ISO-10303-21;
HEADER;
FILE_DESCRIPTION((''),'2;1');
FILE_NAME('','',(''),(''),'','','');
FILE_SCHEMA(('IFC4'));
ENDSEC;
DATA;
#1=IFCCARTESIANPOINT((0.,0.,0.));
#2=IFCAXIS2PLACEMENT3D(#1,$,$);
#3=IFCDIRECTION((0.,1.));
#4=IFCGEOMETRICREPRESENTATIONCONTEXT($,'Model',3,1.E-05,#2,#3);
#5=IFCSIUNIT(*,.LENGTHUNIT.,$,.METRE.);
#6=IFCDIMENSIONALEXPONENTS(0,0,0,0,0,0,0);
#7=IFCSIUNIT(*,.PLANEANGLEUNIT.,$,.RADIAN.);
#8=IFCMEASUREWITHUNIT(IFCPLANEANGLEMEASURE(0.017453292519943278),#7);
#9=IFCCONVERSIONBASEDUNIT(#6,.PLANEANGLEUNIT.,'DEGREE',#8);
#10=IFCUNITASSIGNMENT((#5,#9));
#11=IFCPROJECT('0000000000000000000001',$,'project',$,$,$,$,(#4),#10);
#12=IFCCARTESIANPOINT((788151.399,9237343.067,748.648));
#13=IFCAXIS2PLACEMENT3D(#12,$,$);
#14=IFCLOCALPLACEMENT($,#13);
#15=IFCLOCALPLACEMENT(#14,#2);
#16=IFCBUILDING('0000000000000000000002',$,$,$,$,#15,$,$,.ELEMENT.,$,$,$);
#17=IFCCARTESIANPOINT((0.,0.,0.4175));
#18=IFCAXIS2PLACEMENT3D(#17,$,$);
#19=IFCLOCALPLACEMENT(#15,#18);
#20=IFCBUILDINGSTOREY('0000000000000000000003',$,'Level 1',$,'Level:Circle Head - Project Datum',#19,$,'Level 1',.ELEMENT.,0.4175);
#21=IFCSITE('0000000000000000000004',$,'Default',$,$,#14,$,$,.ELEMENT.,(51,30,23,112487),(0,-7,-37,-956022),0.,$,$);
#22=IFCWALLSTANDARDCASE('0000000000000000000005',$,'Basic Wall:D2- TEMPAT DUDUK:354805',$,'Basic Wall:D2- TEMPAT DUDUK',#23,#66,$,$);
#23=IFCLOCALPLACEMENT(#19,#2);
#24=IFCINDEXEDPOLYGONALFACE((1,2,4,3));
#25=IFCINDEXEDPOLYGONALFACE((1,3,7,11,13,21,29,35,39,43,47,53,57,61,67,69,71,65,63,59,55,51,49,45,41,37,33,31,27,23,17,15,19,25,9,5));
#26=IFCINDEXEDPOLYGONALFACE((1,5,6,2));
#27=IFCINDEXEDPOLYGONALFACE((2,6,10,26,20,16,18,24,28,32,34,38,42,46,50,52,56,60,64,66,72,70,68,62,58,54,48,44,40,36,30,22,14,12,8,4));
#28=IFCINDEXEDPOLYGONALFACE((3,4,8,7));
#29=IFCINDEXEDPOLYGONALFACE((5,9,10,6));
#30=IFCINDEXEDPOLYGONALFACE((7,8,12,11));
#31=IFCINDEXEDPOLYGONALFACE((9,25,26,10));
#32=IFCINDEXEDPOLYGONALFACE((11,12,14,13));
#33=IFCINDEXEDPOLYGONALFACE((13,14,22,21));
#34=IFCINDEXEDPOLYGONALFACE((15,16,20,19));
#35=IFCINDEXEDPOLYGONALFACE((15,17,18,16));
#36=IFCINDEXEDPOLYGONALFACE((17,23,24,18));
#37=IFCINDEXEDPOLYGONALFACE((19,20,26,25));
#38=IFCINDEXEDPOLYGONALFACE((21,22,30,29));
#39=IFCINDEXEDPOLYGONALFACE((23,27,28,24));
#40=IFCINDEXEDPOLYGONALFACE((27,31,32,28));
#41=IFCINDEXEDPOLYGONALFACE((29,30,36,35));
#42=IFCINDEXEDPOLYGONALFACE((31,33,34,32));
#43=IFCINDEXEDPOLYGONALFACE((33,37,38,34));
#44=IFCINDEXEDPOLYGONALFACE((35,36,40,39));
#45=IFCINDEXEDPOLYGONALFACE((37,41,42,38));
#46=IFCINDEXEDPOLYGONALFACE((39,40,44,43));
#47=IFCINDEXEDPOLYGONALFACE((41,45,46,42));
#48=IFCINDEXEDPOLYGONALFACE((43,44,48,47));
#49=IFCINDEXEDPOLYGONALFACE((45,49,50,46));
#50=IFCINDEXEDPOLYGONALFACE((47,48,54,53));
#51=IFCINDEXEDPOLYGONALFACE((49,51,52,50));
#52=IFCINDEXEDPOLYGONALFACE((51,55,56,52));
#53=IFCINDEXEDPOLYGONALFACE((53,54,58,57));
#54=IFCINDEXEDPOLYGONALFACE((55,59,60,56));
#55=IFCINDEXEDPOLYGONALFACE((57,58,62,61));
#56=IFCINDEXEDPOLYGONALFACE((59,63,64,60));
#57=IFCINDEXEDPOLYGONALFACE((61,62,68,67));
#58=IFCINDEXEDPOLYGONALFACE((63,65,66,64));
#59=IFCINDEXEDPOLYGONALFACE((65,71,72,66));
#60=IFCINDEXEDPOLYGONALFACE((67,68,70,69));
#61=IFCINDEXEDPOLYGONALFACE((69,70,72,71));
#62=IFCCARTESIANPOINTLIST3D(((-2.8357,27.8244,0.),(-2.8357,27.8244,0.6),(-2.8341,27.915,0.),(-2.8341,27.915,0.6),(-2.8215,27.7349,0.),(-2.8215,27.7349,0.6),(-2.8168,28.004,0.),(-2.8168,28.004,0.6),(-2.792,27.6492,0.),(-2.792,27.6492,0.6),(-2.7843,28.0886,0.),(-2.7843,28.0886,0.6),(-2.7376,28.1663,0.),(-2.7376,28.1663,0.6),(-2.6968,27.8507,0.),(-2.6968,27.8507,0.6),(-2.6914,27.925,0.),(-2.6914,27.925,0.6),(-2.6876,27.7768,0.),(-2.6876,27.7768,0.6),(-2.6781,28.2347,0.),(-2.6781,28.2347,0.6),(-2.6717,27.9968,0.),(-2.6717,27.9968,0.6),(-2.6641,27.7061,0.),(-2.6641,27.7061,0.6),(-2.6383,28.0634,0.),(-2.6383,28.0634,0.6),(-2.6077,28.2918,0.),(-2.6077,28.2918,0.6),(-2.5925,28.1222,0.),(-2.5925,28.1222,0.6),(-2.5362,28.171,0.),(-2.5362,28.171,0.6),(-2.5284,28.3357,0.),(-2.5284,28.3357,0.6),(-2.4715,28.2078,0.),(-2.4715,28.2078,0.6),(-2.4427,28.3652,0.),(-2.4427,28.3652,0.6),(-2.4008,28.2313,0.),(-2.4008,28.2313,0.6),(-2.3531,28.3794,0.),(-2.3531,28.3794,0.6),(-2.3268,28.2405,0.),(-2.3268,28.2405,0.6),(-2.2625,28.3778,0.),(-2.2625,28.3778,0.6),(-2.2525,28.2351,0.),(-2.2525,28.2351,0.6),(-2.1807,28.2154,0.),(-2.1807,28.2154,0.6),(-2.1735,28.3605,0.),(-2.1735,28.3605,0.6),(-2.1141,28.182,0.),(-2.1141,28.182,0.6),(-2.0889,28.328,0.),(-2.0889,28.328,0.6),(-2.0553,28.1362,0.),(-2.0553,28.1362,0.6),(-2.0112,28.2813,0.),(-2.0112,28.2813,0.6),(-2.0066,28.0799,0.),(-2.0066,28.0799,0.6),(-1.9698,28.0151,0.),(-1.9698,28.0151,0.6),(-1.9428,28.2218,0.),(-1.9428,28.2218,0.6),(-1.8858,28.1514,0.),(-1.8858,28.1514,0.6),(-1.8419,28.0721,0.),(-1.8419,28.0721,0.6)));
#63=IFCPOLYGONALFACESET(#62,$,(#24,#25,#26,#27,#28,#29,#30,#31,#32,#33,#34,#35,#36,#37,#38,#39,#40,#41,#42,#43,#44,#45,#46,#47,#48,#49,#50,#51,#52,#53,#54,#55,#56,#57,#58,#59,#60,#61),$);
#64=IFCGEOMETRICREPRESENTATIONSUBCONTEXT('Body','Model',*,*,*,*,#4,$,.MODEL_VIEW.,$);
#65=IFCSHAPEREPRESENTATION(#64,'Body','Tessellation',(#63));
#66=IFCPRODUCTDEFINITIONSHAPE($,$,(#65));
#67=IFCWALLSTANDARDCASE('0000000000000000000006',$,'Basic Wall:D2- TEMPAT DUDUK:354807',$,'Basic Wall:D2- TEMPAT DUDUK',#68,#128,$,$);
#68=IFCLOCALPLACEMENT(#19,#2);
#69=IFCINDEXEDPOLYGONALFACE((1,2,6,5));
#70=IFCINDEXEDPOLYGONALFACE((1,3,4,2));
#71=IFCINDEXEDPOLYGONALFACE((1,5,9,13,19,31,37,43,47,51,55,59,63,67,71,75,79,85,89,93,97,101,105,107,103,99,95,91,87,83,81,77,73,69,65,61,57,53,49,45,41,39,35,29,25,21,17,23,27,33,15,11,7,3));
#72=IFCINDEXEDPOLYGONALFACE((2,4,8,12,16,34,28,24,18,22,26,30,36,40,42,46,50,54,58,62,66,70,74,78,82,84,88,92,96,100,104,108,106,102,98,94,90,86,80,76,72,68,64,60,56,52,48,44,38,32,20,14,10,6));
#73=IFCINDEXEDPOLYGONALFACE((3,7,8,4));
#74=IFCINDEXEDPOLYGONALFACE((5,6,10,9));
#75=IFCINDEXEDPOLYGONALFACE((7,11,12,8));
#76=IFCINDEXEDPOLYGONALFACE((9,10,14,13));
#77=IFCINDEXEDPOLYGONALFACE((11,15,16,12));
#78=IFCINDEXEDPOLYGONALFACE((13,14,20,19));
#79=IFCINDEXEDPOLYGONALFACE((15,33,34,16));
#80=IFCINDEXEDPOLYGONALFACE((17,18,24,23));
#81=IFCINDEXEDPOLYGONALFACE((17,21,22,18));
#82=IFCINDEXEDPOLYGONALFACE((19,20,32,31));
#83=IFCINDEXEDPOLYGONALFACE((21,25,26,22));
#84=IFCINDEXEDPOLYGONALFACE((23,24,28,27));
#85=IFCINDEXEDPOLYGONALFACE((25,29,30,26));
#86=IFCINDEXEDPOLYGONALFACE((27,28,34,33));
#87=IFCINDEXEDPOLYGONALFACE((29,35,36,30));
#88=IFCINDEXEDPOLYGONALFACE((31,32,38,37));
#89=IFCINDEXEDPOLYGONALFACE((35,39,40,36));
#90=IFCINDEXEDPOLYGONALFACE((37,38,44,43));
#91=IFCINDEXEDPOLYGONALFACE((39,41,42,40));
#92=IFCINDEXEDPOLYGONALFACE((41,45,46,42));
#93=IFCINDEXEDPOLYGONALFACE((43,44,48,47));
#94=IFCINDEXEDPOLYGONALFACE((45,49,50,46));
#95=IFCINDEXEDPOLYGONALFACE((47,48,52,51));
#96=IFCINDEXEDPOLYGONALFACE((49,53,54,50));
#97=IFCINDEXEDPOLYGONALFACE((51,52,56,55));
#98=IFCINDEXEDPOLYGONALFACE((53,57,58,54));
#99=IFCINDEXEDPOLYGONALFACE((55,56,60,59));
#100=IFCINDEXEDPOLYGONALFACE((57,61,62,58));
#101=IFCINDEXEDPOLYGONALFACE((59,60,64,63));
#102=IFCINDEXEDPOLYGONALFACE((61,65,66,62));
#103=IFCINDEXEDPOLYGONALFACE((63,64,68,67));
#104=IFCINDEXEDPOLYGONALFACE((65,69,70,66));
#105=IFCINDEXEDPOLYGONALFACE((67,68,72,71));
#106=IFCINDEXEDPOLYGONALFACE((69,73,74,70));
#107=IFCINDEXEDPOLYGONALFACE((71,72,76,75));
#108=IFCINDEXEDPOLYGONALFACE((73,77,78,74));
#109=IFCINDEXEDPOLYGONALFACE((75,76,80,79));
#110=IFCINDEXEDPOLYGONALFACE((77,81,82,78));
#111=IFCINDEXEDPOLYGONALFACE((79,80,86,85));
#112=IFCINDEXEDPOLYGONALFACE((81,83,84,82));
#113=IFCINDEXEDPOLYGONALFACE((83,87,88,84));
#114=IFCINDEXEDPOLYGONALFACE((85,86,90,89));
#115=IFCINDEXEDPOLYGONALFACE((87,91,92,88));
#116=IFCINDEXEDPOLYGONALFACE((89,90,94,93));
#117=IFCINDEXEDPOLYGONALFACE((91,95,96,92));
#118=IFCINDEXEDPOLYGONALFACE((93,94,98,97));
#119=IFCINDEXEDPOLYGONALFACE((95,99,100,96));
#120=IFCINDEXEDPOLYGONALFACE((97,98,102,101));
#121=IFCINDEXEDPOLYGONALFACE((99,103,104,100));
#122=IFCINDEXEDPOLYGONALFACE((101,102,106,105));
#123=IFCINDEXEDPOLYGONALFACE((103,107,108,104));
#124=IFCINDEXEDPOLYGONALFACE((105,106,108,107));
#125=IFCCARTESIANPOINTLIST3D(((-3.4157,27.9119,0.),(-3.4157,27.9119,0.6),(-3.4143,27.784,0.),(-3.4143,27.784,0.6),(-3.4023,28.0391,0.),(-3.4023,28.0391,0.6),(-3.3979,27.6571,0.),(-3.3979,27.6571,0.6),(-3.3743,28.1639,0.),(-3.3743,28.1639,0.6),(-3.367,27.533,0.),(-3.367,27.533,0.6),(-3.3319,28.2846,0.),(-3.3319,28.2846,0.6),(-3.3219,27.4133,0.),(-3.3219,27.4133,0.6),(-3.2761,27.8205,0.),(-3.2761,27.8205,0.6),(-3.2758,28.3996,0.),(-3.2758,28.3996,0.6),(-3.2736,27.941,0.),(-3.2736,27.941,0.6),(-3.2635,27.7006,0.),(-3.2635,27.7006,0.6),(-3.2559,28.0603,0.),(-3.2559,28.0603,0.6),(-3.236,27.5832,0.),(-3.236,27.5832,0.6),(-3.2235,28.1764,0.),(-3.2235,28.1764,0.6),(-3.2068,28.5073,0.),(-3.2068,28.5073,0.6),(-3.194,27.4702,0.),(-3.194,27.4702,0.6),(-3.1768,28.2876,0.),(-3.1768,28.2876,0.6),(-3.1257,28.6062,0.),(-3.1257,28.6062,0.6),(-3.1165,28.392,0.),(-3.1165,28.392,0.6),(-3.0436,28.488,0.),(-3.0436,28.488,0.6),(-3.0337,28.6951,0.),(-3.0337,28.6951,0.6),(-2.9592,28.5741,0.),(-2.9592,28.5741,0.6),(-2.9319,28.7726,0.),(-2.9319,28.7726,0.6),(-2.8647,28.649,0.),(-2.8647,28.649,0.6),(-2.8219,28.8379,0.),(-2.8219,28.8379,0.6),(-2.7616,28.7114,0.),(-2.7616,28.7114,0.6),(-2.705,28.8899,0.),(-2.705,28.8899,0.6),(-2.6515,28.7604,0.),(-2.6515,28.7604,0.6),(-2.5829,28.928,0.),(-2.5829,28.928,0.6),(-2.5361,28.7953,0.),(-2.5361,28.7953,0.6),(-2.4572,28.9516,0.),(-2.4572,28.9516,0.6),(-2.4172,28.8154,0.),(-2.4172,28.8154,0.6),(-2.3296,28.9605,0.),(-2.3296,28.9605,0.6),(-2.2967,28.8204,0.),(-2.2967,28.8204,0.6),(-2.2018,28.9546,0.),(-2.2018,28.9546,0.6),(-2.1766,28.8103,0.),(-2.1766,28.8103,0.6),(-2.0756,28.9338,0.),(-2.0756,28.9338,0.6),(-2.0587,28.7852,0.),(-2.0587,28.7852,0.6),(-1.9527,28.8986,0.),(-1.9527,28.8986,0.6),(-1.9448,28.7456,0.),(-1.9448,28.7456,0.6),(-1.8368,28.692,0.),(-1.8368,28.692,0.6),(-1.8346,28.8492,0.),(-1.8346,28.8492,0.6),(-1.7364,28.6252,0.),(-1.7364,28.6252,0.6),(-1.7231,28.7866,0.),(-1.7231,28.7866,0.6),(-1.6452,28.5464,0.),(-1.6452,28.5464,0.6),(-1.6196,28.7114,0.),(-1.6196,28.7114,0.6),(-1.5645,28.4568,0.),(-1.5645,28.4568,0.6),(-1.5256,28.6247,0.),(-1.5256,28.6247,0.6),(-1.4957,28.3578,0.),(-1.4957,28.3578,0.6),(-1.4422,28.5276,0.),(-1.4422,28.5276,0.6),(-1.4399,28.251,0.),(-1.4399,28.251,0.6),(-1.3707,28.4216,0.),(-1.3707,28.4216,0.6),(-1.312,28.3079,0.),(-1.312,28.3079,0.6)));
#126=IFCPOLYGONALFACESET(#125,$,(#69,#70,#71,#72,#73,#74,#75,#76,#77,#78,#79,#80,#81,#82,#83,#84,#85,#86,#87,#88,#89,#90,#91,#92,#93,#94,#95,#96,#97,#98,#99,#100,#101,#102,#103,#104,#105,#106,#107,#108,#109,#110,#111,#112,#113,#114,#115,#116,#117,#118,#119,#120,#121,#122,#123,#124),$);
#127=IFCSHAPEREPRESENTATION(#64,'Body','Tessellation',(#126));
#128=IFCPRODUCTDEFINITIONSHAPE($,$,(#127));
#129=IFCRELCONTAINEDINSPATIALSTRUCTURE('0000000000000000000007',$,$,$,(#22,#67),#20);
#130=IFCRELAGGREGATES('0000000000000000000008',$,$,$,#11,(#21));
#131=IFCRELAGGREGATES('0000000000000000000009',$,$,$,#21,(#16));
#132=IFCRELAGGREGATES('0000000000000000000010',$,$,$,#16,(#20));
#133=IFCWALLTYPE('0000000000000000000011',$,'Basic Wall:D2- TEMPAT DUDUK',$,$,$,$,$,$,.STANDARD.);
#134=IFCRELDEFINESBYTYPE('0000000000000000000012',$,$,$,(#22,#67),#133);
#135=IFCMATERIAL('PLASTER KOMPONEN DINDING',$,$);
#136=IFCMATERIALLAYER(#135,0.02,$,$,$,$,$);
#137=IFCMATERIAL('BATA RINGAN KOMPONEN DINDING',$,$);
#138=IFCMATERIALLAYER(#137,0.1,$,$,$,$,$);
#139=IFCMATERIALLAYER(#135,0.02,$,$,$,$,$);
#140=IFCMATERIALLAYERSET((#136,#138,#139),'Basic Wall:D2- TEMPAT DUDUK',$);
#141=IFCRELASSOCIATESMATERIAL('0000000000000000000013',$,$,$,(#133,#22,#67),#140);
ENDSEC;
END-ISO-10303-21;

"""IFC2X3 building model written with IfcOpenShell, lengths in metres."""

from ifc_helpers import new_model, entity, si_unit, converted_unit, direction, frame, frame_2d, origin, place, context, subcontext, project, spatial, polyline, circle_curve, parameter, trimmed, segment, composite_curve, outline, extrude, material, layer, layer_set, layer_usage, type_object, element, save


model = new_model("IFC2X3")

# Units and contexts
model_context = context("Model", 3, precision=1e-05, world=origin(), true_north=direction((0.0, 1.0)))
body_context = subcontext(model_context, "Body", "Model", "MODEL_VIEW")
ifc_project = project(units=[si_unit("LENGTHUNIT", "METRE"), converted_unit("PLANEANGLEUNIT", "DEGREE", entity("IfcPlaneAngleMeasure", 0.017453292519943278), si_unit("PLANEANGLEUNIT", "RADIAN"), dimensions=[0, 0, 0, 0, 0, 0, 0])], contexts=[model_context])

# Site, building, storey
site_placement = place(None, frame((788151.399, 9237343.067, 748.648)))
site = spatial("IfcSite", under=ifc_project, at=site_placement, Name="Default", CompositionType="ELEMENT", RefLatitude=(51, 30, 23, 112487), RefLongitude=(0, -7, -37, -956022), RefElevation=0.0)
building_placement = place(site_placement, origin())
building = spatial("IfcBuilding", under=site, at=building_placement, CompositionType="ELEMENT")
storey_placement = place(building_placement, frame((0.0, 0.0, 0.4175)))
storey = spatial("IfcBuildingStorey", under=building, at=storey_placement, Name="Level 1", ObjectType="Level:Circle Head - Project Datum", LongName="Level 1", CompositionType="ELEMENT", Elevation=0.4175)

# Walls
ifc_material_1 = material(Name="PLASTER KOMPONEN DINDING")
ifc_material_2 = material(Name="BATA RINGAN KOMPONEN DINDING")
ifc_layer_1 = layer(ifc_material_1, 0.02)
ifc_layer_2 = layer(ifc_material_2, 0.1)
ifc_layer_3 = layer(ifc_material_1, 0.02)
ifc_layer_set_1 = layer_set([ifc_layer_1, ifc_layer_2, ifc_layer_3], Name="Basic Wall:D2- TEMPAT DUDUK")
ifc_layer_usage_1 = layer_usage(ifc_layer_set_1, "AXIS2", "NEGATIVE", 0.07)
wall_type_1 = type_object("IfcWallType", Name="Basic Wall:D2- TEMPAT DUDUK", PredefinedType="STANDARD", material=ifc_layer_set_1)
wall_1_placement = place(storey_placement, frame((-2.728, 27.6776, 0.0), z_axis=(0.0, 0.0, 1.0), x_axis=(-0.913586, -0.406645, 0.0)))
element("IfcWallStandardCase", 1, at=wall_1_placement, inside=storey, type_object=wall_type_1, material=ifc_layer_usage_1, Name="Basic Wall:D2- TEMPAT DUDUK:354805", ObjectType="Basic Wall:D2- TEMPAT DUDUK", context=body_context, shape_type="SweptSolid", body=[
    extrude(outline(composite_curve([segment(trimmed(circle_curve(frame_2d((-0.45, 0.0), x_axis=(1.0, 0.0)), 0.52), [parameter(180.0)], [parameter(0.0)], True, "PARAMETER"), True, "CONTINUOUS"), segment(polyline([(0.07, 0.0), (-0.07, 0.0)]), True, "CONTINUOUS"), segment(trimmed(circle_curve(frame_2d((-0.45, 0.0), x_axis=(1.0, 0.0)), 0.38), [parameter(180.0)], [parameter(0.0)], True, "PARAMETER"), False, "CONTINUOUS"), segment(polyline([(-0.83, 0.0), (-0.97, 0.0)]), True, "CONTINUOUS")], self_intersect=False)), origin(), (0.0, 0.0, 1.0), 0.6),
])
ifc_layer_usage_2 = layer_usage(ifc_layer_set_1, "AXIS2", "NEGATIVE", 0.07)
wall_2_placement = place(storey_placement, frame((-3.2579, 27.4418, 0.0), z_axis=(0.0, 0.0, 1.0), x_axis=(-0.913586, -0.406645, 0.0)))
element("IfcWallStandardCase", 2, at=wall_2_placement, inside=storey, type_object=wall_type_1, material=ifc_layer_usage_2, Name="Basic Wall:D2- TEMPAT DUDUK:354807", ObjectType="Basic Wall:D2- TEMPAT DUDUK", context=body_context, shape_type="SweptSolid", body=[
    extrude(outline(composite_curve([segment(trimmed(circle_curve(frame_2d((-1.03, 0.0), x_axis=(1.0, 0.0)), 1.1), [parameter(180.0)], [parameter(0.0)], True, "PARAMETER"), True, "CONTINUOUS"), segment(polyline([(0.07, 0.0), (-0.07, 0.0)]), True, "CONTINUOUS"), segment(trimmed(circle_curve(frame_2d((-1.03, 0.0), x_axis=(1.0, 0.0)), 0.96), [parameter(180.0)], [parameter(0.0)], True, "PARAMETER"), False, "CONTINUOUS"), segment(polyline([(-1.99, 0.0), (-2.13, 0.0)]), True, "CONTINUOUS")], self_intersect=False)), origin(), (0.0, 0.0, 1.0), 0.6),
])

save(model, "model.ifc")
